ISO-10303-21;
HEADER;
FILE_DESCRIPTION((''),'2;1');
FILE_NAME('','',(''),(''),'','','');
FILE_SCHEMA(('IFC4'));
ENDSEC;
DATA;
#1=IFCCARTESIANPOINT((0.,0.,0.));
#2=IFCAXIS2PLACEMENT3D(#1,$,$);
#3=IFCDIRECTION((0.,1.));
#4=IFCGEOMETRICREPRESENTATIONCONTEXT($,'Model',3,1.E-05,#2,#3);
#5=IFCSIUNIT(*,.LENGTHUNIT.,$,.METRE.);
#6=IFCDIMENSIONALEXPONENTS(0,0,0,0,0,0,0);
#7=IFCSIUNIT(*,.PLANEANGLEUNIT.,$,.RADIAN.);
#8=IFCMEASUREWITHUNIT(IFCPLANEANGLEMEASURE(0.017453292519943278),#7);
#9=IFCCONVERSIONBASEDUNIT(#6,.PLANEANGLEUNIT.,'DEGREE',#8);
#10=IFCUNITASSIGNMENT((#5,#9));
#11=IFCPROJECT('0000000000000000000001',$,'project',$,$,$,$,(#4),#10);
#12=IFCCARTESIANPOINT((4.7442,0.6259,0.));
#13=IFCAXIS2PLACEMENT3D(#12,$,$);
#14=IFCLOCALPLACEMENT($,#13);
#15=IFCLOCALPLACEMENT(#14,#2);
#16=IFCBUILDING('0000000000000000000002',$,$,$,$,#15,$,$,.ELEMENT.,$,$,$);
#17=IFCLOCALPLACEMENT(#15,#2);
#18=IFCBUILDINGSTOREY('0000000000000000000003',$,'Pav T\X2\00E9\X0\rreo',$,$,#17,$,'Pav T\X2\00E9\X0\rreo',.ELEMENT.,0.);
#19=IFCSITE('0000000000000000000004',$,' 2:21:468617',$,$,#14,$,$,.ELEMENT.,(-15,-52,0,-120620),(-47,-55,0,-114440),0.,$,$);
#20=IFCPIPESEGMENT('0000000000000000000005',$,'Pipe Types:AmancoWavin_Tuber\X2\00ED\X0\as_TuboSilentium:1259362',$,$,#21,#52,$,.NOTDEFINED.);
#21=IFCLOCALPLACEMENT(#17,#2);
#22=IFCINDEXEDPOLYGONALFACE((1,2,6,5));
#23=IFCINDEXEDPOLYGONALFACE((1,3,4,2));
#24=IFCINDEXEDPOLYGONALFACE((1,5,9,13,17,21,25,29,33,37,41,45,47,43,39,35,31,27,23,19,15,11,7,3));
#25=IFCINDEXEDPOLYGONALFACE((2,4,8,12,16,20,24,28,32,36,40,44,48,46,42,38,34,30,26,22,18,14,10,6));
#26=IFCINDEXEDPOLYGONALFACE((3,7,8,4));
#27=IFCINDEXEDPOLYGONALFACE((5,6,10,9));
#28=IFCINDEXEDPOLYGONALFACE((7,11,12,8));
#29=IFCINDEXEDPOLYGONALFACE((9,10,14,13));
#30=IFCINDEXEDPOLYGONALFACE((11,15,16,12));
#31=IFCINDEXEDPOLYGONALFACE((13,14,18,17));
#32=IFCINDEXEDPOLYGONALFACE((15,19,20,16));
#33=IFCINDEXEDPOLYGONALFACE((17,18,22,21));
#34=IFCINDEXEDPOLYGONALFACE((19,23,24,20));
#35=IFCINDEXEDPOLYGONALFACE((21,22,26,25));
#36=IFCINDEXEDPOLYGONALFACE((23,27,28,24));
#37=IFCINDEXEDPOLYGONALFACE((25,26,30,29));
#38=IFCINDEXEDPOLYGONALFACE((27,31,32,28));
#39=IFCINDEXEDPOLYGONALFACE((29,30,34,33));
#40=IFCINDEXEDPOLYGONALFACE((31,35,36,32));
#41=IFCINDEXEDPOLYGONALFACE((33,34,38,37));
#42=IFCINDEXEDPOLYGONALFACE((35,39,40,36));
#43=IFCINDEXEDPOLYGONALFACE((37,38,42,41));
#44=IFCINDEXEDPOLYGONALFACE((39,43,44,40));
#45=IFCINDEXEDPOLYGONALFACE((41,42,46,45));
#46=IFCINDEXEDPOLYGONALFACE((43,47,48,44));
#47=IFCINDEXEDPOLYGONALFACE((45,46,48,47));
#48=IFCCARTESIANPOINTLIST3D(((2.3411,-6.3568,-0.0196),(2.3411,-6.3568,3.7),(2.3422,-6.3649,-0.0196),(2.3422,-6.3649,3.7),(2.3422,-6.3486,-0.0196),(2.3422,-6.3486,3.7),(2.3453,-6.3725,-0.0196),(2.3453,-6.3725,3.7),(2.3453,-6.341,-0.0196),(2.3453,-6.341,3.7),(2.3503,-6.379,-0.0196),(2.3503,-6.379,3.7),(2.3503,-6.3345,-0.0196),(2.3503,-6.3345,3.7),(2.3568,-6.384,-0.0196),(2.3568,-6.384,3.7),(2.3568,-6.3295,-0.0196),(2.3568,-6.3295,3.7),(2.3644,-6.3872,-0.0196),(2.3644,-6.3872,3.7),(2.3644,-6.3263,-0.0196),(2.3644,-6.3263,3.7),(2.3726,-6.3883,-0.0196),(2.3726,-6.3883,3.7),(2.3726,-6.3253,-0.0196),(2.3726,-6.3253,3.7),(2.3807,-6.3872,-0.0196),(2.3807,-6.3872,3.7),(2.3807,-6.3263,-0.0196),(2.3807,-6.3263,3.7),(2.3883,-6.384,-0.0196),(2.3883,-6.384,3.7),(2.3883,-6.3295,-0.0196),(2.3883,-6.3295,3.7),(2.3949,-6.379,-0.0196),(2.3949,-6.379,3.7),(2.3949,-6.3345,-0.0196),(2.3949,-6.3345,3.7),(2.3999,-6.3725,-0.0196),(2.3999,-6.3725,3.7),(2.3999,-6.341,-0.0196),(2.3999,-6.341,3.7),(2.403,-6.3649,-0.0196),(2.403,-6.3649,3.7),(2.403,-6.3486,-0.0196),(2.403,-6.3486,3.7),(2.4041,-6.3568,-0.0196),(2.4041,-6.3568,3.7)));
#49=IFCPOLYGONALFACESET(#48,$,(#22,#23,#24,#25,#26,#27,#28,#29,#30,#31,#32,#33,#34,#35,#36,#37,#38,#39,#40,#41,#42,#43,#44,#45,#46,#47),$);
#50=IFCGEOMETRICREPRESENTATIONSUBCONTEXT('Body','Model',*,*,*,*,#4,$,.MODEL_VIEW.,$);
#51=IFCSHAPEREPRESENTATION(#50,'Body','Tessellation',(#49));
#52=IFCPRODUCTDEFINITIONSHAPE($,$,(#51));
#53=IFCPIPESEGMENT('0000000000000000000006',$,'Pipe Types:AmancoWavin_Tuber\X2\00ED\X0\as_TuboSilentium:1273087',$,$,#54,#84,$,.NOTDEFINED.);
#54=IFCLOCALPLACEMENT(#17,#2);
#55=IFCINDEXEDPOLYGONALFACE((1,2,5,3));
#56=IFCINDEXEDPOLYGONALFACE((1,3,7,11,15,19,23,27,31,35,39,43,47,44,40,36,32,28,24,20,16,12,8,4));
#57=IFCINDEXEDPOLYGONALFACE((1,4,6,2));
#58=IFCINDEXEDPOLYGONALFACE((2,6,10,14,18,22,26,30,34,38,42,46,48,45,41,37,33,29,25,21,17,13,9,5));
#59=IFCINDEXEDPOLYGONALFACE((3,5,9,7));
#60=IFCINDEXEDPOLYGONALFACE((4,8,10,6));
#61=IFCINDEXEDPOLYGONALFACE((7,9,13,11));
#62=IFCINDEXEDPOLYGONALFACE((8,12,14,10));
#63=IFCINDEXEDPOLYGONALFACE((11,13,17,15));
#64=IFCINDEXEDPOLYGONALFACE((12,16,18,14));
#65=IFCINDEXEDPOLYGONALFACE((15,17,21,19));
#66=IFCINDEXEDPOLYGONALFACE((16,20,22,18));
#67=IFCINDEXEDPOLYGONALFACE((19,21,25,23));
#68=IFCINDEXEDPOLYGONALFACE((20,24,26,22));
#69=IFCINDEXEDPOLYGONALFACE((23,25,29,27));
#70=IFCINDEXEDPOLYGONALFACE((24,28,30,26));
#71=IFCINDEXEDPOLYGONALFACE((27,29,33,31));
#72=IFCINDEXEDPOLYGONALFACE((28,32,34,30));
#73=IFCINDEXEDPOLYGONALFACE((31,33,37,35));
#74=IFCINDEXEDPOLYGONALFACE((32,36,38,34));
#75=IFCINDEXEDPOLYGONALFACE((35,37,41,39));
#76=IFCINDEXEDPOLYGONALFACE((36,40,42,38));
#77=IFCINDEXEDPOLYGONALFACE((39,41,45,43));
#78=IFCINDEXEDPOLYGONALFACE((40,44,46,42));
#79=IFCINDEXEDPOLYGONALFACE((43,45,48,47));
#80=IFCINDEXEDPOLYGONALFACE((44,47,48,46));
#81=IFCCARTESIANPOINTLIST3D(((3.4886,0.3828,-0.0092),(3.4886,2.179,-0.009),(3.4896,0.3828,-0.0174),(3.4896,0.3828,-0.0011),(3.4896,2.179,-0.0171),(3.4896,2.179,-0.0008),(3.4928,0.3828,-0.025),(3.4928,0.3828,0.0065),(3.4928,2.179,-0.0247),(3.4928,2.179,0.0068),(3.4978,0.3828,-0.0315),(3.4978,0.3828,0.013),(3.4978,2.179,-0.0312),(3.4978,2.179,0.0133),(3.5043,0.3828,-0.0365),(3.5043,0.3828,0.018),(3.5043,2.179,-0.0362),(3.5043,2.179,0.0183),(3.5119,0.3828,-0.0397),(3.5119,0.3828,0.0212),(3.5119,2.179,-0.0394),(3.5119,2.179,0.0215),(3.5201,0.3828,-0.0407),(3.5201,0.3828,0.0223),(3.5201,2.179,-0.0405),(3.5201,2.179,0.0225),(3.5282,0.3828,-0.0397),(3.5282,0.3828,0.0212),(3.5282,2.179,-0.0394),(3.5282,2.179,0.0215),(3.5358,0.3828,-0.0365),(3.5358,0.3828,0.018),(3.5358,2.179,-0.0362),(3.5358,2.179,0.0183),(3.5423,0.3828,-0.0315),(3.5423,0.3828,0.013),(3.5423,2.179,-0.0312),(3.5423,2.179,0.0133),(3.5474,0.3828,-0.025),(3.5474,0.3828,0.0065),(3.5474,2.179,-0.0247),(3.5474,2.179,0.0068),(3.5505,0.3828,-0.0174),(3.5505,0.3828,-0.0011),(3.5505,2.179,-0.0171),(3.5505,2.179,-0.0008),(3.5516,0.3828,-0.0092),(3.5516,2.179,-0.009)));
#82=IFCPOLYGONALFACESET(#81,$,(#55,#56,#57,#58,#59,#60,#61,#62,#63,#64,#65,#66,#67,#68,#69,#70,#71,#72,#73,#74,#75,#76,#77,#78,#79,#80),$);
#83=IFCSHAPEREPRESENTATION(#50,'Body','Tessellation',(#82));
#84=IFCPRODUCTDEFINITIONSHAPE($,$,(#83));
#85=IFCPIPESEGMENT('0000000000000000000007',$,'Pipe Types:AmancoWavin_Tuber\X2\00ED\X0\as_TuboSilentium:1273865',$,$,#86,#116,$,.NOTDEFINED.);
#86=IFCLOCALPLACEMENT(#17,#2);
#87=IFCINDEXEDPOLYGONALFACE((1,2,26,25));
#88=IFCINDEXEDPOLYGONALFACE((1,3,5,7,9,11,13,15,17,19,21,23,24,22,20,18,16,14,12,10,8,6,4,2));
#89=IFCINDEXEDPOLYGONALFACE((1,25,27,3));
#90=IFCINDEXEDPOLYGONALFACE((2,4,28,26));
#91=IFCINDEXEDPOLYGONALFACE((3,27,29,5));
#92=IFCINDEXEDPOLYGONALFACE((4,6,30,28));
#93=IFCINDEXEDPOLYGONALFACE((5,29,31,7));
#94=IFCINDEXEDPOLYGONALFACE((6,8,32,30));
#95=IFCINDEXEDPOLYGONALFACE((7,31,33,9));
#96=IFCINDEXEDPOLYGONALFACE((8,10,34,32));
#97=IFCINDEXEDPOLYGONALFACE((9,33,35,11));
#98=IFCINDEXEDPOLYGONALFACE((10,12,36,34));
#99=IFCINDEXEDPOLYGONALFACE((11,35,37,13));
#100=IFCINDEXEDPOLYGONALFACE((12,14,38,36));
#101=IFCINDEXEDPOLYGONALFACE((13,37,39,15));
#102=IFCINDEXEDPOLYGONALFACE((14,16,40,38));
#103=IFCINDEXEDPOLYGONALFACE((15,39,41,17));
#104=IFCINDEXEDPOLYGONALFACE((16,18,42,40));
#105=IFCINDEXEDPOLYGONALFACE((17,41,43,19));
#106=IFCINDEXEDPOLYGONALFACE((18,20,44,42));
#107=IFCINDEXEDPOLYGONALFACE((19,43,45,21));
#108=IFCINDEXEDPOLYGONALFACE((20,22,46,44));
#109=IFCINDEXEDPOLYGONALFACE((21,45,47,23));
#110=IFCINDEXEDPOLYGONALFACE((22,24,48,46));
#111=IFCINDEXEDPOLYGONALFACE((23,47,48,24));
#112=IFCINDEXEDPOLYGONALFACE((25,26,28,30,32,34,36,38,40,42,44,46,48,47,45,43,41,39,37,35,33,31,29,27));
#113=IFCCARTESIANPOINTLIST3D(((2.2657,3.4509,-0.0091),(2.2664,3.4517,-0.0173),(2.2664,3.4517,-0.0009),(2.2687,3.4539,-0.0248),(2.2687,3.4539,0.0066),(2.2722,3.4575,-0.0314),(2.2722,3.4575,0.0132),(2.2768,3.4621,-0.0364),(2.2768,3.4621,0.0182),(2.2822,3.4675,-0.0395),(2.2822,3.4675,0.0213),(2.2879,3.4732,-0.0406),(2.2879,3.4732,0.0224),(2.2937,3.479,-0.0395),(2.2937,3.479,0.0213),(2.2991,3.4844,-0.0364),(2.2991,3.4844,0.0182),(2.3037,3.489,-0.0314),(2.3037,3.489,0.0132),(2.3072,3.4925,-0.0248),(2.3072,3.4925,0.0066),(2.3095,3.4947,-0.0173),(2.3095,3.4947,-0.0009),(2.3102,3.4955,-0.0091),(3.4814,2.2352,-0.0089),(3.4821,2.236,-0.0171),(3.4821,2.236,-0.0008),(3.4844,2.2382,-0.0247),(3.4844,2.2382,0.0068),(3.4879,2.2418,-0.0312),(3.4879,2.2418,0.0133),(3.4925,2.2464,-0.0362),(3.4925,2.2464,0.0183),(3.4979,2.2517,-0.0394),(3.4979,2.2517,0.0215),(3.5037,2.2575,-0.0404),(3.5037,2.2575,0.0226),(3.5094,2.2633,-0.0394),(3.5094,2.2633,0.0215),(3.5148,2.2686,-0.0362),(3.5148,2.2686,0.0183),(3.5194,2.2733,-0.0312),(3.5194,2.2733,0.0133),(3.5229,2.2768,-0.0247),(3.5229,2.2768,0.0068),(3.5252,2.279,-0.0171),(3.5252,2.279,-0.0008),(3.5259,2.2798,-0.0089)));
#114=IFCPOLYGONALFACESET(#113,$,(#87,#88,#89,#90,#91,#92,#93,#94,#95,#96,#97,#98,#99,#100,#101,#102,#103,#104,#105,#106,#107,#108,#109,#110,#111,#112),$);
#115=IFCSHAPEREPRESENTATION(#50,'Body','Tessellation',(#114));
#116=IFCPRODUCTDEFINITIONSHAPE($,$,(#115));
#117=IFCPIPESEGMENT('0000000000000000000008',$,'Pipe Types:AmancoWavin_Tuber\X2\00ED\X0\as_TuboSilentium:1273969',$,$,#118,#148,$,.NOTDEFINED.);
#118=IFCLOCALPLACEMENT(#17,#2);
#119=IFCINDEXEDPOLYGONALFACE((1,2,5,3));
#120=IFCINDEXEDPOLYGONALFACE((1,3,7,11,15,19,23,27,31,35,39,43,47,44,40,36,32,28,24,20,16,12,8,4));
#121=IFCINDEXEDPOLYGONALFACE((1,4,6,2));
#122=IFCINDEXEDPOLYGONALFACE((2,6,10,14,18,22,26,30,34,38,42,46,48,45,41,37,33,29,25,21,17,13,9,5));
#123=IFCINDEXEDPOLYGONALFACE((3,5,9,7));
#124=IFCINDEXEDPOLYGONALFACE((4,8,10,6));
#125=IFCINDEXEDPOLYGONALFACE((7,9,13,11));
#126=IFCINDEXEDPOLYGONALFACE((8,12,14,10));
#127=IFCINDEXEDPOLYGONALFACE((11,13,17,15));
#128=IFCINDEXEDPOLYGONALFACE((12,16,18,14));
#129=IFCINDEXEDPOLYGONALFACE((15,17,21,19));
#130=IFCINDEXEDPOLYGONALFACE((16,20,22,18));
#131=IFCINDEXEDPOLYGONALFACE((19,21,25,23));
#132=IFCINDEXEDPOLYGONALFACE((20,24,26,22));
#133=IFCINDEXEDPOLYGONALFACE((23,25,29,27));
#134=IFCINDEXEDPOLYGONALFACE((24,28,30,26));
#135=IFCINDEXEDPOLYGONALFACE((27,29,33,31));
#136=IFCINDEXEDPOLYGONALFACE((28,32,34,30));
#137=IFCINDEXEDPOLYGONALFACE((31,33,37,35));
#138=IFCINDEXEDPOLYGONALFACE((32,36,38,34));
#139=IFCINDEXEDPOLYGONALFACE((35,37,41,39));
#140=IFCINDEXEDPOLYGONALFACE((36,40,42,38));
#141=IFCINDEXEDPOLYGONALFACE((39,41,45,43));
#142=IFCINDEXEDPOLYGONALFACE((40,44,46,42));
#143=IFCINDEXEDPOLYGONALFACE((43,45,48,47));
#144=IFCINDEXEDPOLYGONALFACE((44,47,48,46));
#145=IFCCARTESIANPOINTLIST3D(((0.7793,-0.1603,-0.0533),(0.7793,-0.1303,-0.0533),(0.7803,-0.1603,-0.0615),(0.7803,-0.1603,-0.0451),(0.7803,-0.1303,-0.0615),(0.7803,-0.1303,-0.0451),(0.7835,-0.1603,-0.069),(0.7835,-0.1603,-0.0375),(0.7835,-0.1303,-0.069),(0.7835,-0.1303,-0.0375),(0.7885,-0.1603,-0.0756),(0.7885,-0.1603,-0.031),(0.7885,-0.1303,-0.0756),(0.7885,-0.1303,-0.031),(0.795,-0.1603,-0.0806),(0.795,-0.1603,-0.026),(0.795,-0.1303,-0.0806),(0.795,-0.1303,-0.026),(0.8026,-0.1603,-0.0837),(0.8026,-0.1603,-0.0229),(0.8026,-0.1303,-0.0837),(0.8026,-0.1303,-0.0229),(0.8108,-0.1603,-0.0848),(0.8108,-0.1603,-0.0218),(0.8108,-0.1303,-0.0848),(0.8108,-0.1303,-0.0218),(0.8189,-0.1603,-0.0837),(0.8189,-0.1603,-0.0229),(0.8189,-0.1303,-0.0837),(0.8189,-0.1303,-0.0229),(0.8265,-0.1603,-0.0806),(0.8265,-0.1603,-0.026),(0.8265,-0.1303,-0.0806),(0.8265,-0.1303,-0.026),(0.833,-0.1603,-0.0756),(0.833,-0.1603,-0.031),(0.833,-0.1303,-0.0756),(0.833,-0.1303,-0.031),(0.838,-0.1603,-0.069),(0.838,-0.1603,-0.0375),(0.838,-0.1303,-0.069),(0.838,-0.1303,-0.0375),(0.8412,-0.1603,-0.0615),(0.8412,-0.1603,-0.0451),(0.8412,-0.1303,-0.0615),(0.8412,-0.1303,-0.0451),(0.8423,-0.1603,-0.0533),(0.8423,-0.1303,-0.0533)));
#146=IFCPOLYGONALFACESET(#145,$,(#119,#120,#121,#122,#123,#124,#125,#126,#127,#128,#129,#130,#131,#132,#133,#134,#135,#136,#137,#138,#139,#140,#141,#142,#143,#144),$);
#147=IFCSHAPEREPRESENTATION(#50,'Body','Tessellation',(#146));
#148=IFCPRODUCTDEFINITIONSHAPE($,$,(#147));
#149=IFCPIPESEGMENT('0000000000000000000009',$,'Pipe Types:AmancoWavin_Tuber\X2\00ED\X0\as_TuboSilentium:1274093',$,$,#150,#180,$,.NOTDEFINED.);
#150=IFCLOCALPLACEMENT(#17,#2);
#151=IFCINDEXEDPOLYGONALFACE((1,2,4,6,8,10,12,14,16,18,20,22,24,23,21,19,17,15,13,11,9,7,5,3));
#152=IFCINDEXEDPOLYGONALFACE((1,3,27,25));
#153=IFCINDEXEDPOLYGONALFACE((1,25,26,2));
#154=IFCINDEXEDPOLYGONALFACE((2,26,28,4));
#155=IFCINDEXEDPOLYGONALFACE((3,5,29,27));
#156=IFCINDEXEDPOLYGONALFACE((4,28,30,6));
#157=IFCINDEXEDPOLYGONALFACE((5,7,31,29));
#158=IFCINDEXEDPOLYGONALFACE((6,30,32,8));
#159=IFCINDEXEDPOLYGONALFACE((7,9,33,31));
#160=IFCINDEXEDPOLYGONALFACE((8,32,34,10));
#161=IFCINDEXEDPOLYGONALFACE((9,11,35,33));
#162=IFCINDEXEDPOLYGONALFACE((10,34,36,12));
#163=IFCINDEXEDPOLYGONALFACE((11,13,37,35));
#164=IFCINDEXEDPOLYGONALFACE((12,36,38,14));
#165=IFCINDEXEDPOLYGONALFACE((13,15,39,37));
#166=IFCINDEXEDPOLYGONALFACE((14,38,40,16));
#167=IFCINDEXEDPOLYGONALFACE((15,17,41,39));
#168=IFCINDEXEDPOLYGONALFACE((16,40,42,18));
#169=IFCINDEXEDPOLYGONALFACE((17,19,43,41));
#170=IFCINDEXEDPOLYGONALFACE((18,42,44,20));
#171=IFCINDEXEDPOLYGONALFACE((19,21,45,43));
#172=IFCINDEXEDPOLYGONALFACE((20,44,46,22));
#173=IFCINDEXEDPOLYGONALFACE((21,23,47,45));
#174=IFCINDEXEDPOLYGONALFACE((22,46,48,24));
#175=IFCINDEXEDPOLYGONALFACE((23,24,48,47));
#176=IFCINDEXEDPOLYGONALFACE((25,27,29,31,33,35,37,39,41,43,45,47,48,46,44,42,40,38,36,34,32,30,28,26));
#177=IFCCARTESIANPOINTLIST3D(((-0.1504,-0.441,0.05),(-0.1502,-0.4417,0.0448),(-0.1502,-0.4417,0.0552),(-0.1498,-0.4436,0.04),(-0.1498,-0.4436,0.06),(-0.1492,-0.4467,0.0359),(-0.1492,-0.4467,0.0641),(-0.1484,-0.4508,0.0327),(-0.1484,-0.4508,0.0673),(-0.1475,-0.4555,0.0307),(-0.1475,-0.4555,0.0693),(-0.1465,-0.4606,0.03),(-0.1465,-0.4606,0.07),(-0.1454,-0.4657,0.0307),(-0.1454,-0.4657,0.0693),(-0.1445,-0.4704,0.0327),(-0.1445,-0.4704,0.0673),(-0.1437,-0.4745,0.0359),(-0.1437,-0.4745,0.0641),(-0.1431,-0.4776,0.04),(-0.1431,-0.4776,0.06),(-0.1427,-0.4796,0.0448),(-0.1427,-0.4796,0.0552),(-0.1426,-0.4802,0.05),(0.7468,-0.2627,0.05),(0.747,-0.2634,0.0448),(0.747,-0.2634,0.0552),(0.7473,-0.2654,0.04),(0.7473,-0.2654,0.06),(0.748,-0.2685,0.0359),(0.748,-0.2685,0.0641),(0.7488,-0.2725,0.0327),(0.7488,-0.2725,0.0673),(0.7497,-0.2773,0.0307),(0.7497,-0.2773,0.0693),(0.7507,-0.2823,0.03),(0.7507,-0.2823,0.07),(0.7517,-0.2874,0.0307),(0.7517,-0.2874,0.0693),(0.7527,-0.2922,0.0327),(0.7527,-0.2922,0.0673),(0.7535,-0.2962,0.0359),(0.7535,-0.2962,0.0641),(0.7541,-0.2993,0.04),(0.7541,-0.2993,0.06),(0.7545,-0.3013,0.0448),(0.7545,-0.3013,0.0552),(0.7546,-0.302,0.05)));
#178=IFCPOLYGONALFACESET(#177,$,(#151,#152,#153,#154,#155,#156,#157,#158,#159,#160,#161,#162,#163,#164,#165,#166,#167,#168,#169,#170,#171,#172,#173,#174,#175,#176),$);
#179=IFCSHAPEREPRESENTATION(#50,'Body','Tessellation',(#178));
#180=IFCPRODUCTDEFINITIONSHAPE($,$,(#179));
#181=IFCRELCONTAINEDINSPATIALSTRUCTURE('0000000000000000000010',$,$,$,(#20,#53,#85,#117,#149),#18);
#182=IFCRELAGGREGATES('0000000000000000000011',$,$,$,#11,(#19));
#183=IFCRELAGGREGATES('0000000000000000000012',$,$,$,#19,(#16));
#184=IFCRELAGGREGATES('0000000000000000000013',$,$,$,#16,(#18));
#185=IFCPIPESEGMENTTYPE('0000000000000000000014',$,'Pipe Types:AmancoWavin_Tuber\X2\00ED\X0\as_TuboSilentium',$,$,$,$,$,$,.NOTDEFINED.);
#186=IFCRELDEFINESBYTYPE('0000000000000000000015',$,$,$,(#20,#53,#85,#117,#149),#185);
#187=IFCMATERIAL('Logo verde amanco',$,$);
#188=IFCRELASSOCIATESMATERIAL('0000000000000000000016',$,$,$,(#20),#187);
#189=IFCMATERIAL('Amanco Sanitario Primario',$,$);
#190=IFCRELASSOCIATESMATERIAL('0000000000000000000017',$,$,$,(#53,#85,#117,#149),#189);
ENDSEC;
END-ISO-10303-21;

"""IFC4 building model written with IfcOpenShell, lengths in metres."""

from ifc_helpers import new_model, entity, si_unit, converted_unit, direction, frame, origin, place, context, subcontext, project, spatial, arc, indexed_curve, outline, extrude, material, type_object, element, save


model = new_model("IFC4")

# Units and contexts
model_context = context("Model", 3, precision=1e-05, world=origin(), true_north=direction((0.0, 1.0)))
body_context = subcontext(model_context, "Body", "Model", "MODEL_VIEW")
ifc_project = project(units=[si_unit("LENGTHUNIT", "METRE"), converted_unit("PLANEANGLEUNIT", "DEGREE", entity("IfcPlaneAngleMeasure", 0.017453292519943278), si_unit("PLANEANGLEUNIT", "RADIAN"), dimensions=[0, 0, 0, 0, 0, 0, 0])], contexts=[model_context])

# Site, building, storey
site_placement = place(None, frame((4.7442, 0.6259, 0.0)))
site = spatial("IfcSite", under=ifc_project, at=site_placement, Name=" 2:21:468617", CompositionType="ELEMENT", RefLatitude=(-15, -52, 0, -120620), RefLongitude=(-47, -55, 0, -114440), RefElevation=0.0)
building_placement = place(site_placement, origin())
building = spatial("IfcBuilding", under=site, at=building_placement, CompositionType="ELEMENT")
storey_placement = place(building_placement, origin())
storey = spatial("IfcBuildingStorey", under=building, at=storey_placement, Name="Pav Térreo", LongName="Pav Térreo", CompositionType="ELEMENT", Elevation=0.0)

# Pipe segments
ifc_material_1 = material(Name="Logo verde amanco")
pipe_segment_type_1 = type_object("IfcPipeSegmentType", Name="Pipe Types:AmancoWavin_Tuberías_TuboSilentium", PredefinedType="NOTDEFINED")
pipe_segment_1_placement = place(storey_placement, origin())
element("IfcPipeSegment", 1, at=pipe_segment_1_placement, inside=storey, type_object=pipe_segment_type_1, material=ifc_material_1, Name="Pipe Types:AmancoWavin_Tuberías_TuboSilentium:1259362", PredefinedType="NOTDEFINED", context=body_context, shape_type="SweptSolid", body=[
    extrude(outline(indexed_curve([(0.0315, 0.0), (0.0223, 0.0223), (0.0, 0.0315), (-0.0223, 0.0223), (-0.0315, 0.0), (-0.0223, -0.0223), (0.0, -0.0315), (0.0223, -0.0223)], segments=[arc(1, 2, 3), arc(3, 4, 5), arc(5, 6, 7), arc(7, 8, 1)], self_intersect=False)), frame((2.3726, -6.3568, -0.0196), z_axis=(0.0, 0.0, 1.0), x_axis=(-1.0, 0.0, 0.0)), (0.0, 0.0, 1.0), 3.7196),
])
ifc_material_2 = material(Name="Amanco Sanitario Primario")
pipe_segment_2_placement = place(storey_placement, origin())
element("IfcPipeSegment", 2, at=pipe_segment_2_placement, inside=storey, type_object=pipe_segment_type_1, material=ifc_material_2, Name="Pipe Types:AmancoWavin_Tuberías_TuboSilentium:1273087", PredefinedType="NOTDEFINED", context=body_context, shape_type="SweptSolid", body=[
    extrude(outline(indexed_curve([(0.0315, 0.0), (0.0223, 0.0223), (0.0, 0.0315), (-0.0223, 0.0223), (-0.0315, 0.0), (-0.0223, -0.0223), (0.0, -0.0315), (0.0223, -0.0223)], segments=[arc(1, 2, 3), arc(3, 4, 5), arc(5, 6, 7), arc(7, 8, 1)], self_intersect=False)), frame((3.5201, 0.3828, -0.0092), z_axis=(0.0, 1.0, 0.000161), x_axis=(-1.0, 0.0, 0.0)), (0.0, 0.0, 1.0), 1.7962),
])
pipe_segment_3_placement = place(storey_placement, origin())
element("IfcPipeSegment", 3, at=pipe_segment_3_placement, inside=storey, type_object=pipe_segment_type_1, material=ifc_material_2, Name="Pipe Types:AmancoWavin_Tuberías_TuboSilentium:1273865", PredefinedType="NOTDEFINED", context=body_context, shape_type="SweptSolid", body=[
    extrude(outline(indexed_curve([(0.0315, 0.0), (0.0223, 0.0223), (0.0, 0.0315), (-0.0223, 0.0223), (-0.0315, 0.0), (-0.0223, -0.0223), (0.0, -0.0315), (0.0223, -0.0223)], segments=[arc(1, 2, 3), arc(3, 4, 5), arc(5, 6, 7), arc(7, 8, 1)], self_intersect=False)), frame((3.5037, 2.2575, -0.0089), z_axis=(-0.707107, 0.707107, -0.00009), x_axis=(0.707107, 0.707107, 0.0)), (0.0, 0.0, 1.0), 1.7193),
])
pipe_segment_4_placement = place(storey_placement, origin())
element("IfcPipeSegment", 4, at=pipe_segment_4_placement, inside=storey, type_object=pipe_segment_type_1, material=ifc_material_2, Name="Pipe Types:AmancoWavin_Tuberías_TuboSilentium:1273969", PredefinedType="NOTDEFINED", context=body_context, shape_type="SweptSolid", body=[
    extrude(outline(indexed_curve([(0.0315, 0.0), (0.0223, 0.0223), (0.0, 0.0315), (-0.0223, 0.0223), (-0.0315, 0.0), (-0.0223, -0.0223), (0.0, -0.0315), (0.0223, -0.0223)], segments=[arc(1, 2, 3), arc(3, 4, 5), arc(5, 6, 7), arc(7, 8, 1)], self_intersect=False)), frame((0.8108, -0.1603, -0.0533), z_axis=(0.0, 1.0, 0.0), x_axis=(1.0, 0.0, 0.0)), (0.0, 0.0, 1.0), 0.03),
])
pipe_segment_5_placement = place(storey_placement, origin())
element("IfcPipeSegment", 5, at=pipe_segment_5_placement, inside=storey, type_object=pipe_segment_type_1, material=ifc_material_2, Name="Pipe Types:AmancoWavin_Tuberías_TuboSilentium:1274093", PredefinedType="NOTDEFINED", context=body_context, shape_type="SweptSolid", body=[
    extrude(outline(indexed_curve([(0.02, 0.0), (0.0141, 0.0141), (0.0, 0.02), (-0.0141, 0.0141), (-0.02, 0.0), (-0.0141, -0.0141), (0.0, -0.02), (0.0141, -0.0141)], segments=[arc(1, 2, 3), arc(3, 4, 5), arc(5, 6, 7), arc(7, 8, 1)], self_intersect=False)), frame((-0.1465, -0.4606, 0.05), z_axis=(0.980826, 0.194885, 0.0), x_axis=(0.194885, -0.980826, 0.0)), (0.0, 0.0, 1.0), 0.9147),
])

save(model, "model.ifc")
